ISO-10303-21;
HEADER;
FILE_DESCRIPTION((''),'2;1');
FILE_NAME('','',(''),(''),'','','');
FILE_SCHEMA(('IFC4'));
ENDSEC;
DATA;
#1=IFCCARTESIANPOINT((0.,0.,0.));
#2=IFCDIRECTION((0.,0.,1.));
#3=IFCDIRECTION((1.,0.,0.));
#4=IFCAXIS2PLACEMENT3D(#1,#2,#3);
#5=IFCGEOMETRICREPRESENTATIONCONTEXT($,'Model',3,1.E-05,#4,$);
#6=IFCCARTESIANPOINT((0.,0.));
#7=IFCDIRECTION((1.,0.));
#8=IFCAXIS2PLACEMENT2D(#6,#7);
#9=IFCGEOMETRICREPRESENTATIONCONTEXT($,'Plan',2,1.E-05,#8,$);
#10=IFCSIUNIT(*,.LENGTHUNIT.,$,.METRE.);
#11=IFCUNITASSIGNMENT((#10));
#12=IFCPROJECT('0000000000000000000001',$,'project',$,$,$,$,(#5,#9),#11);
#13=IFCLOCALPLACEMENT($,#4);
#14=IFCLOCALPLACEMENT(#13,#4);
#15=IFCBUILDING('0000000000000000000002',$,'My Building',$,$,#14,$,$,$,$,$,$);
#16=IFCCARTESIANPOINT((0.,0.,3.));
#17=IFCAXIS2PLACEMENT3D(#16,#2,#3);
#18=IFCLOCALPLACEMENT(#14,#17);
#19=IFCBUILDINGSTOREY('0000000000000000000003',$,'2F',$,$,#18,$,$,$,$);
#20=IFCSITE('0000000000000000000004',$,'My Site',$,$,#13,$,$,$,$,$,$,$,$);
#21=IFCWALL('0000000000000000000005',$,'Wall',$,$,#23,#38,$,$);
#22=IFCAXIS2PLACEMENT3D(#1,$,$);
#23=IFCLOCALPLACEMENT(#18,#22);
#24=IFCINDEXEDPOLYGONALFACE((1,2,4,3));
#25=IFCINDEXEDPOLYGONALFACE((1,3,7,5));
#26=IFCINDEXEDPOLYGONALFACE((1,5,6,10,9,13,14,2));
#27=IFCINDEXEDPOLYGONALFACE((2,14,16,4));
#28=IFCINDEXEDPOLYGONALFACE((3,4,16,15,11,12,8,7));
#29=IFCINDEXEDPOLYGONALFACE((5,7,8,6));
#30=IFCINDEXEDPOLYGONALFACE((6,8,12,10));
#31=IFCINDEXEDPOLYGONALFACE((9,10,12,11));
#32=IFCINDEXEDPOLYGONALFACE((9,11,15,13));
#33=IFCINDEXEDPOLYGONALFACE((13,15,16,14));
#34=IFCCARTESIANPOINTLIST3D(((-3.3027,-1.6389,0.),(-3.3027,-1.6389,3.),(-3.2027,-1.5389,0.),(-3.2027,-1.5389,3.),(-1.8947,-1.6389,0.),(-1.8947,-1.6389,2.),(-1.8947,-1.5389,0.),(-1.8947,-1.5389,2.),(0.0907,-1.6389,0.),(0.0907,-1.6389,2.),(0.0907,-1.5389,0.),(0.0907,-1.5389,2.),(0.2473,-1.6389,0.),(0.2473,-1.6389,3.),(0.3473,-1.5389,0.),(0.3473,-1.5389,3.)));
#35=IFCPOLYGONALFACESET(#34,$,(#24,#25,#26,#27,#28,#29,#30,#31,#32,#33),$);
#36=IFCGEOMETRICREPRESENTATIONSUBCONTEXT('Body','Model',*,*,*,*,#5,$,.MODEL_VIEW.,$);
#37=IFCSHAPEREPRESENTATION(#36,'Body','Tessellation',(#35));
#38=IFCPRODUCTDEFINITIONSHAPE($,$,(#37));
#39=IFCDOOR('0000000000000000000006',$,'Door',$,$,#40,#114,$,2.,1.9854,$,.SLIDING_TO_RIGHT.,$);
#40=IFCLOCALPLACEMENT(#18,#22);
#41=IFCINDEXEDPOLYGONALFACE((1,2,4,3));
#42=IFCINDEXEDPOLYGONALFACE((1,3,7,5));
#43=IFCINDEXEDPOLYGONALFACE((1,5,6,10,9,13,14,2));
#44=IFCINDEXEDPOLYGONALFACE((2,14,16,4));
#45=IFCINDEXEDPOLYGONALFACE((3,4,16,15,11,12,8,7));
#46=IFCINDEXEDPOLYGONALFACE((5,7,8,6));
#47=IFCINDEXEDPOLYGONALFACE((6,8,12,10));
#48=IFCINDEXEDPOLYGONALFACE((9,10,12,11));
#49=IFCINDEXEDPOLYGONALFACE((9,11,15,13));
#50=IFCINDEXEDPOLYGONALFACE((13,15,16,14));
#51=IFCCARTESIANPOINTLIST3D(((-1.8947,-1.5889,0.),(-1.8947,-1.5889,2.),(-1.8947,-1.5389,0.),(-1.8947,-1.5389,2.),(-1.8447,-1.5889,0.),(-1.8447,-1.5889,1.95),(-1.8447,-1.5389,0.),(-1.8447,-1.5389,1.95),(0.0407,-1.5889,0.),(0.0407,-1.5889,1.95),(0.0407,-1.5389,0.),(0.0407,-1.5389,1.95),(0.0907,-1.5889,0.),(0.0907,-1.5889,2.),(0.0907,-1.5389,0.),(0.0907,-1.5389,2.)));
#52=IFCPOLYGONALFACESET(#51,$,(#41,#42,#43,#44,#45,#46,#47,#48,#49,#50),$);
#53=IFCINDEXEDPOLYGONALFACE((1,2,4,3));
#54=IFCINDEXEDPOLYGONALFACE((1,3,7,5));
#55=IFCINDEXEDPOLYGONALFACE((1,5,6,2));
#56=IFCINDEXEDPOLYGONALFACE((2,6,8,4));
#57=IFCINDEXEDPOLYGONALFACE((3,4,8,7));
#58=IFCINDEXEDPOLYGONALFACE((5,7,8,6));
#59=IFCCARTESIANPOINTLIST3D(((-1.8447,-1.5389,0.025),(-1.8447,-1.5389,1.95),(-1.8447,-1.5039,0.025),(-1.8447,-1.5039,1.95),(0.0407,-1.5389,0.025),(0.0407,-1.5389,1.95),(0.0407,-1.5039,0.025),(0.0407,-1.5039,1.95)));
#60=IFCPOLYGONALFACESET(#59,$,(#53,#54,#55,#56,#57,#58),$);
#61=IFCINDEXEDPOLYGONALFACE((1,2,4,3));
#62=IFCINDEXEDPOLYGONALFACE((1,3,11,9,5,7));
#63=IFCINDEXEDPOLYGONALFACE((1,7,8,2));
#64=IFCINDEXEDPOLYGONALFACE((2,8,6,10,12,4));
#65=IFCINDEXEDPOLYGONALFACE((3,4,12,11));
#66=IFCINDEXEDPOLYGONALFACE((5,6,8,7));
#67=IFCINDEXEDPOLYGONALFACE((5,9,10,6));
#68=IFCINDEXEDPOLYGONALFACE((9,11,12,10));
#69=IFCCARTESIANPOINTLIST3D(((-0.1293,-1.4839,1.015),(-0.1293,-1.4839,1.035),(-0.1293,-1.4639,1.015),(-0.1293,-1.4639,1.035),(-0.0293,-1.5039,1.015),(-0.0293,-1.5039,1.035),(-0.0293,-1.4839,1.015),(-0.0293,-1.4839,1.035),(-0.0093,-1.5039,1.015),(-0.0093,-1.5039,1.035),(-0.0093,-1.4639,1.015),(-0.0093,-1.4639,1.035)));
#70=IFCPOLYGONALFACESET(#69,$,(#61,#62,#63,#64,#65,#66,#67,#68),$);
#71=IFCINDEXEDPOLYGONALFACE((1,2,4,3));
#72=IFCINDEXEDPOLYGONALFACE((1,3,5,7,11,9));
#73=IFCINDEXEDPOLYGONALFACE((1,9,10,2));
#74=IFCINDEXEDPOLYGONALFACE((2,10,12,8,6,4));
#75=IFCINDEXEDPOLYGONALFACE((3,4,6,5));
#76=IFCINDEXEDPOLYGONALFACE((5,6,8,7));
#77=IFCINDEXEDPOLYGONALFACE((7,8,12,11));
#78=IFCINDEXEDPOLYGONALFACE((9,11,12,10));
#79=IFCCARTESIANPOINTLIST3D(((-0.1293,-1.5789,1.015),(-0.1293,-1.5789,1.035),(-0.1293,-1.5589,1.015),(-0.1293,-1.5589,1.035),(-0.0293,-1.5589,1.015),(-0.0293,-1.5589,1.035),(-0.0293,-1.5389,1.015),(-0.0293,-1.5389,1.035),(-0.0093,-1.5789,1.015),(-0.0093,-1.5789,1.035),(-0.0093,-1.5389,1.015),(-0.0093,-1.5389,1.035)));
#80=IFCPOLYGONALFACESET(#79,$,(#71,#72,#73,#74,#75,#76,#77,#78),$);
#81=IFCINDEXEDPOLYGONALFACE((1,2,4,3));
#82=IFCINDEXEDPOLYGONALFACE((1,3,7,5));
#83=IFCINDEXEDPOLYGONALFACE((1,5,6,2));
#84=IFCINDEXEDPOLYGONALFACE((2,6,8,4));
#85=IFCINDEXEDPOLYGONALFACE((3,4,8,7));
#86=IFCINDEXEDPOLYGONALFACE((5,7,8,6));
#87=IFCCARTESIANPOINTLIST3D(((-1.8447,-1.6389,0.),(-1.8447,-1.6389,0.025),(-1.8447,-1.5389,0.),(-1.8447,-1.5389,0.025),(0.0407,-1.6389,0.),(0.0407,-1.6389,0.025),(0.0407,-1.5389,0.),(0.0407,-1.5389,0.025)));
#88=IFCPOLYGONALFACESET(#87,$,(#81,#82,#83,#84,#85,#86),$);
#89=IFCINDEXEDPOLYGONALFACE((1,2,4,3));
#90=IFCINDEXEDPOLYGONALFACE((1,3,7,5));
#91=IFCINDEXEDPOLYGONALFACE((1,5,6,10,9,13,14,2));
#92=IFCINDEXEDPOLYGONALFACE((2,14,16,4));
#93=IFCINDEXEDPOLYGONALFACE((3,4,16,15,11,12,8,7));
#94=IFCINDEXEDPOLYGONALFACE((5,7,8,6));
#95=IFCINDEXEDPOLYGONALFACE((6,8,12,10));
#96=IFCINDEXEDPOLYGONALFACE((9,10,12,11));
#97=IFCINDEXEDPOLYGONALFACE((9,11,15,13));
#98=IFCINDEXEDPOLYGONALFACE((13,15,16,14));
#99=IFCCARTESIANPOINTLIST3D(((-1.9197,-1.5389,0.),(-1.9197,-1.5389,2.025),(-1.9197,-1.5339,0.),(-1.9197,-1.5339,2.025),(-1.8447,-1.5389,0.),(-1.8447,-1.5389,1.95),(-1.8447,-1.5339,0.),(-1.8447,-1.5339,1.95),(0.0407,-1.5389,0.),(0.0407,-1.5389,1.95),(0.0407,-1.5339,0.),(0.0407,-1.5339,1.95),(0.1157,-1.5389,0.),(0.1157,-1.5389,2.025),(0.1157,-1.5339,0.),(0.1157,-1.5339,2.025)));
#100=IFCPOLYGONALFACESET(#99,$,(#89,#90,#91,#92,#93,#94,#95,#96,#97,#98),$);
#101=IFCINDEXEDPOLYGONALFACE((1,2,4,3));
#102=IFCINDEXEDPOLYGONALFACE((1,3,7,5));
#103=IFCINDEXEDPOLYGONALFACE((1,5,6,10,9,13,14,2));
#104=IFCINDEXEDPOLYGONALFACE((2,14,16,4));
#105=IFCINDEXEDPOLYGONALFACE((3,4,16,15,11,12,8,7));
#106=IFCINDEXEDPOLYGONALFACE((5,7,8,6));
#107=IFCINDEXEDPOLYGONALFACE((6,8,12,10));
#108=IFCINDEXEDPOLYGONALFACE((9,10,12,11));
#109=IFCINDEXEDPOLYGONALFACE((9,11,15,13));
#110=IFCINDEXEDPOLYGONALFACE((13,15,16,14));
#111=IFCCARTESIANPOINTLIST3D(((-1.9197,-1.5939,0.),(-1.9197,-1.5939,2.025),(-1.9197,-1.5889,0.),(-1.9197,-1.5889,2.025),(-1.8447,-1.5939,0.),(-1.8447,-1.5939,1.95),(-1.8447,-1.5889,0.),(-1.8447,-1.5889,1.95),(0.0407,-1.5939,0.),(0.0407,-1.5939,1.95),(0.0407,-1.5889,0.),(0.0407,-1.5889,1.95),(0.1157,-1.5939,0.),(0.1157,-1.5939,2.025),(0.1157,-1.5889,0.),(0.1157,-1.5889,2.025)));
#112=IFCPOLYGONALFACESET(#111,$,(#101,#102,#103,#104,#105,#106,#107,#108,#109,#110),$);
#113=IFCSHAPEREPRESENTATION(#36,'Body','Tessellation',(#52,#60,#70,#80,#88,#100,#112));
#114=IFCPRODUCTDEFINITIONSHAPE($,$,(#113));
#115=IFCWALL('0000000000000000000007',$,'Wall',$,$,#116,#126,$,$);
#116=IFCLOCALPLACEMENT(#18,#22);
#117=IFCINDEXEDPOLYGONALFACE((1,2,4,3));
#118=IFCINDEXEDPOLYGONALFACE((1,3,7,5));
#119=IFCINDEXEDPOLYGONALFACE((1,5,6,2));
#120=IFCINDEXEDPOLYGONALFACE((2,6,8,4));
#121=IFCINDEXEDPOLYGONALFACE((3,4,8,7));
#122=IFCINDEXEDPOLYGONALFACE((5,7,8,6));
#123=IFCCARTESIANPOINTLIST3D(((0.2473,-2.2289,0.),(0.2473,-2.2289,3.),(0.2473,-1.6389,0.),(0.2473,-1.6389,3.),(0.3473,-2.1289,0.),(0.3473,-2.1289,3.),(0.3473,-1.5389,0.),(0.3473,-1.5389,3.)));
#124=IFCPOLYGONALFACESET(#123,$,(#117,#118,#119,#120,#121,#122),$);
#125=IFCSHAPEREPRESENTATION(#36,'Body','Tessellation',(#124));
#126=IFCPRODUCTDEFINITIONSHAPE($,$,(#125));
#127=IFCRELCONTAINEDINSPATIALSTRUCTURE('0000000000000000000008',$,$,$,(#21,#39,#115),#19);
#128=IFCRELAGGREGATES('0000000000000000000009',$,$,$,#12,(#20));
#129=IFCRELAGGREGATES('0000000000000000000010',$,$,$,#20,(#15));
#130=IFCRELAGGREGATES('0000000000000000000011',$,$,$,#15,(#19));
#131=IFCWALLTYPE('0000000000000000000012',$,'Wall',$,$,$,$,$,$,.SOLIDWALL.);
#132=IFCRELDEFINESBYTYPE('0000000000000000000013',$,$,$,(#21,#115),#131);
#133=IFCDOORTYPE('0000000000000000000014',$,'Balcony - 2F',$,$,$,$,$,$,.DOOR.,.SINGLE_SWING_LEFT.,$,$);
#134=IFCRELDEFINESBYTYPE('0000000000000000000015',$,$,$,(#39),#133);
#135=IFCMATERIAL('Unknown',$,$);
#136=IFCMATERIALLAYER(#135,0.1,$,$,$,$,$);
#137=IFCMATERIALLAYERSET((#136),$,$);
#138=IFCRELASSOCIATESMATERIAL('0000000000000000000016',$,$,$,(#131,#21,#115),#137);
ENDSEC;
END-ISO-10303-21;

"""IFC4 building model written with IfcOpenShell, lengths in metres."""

from ifc_helpers import new_model, entity, si_unit, frame, origin_with_axes, origin_2d_with_axis, place, context, subcontext, project, spatial, line, indexed_curve, outline, extrude, shape, source, transform, mapped, material, layer, layer_set, layer_usage, type_object, type_shapes, element, fill, save


model = new_model("IFC4")

# Units and contexts
model_context = context("Model", 3, precision=1e-05, world=origin_with_axes())
plan_context = context("Plan", 2, precision=1e-05, world=origin_2d_with_axis())
body_context_1 = subcontext(model_context, "Body", "Model", "MODEL_VIEW")
body_context_2 = subcontext(plan_context, "Body", "Plan", "PLAN_VIEW")
ifc_project = project(units=[si_unit("LENGTHUNIT", "METRE")], contexts=[model_context, plan_context])

# Site, building, storey
site_placement = place(None, origin_with_axes())
site = spatial("IfcSite", under=ifc_project, at=site_placement, Name="My Site")
building_placement = place(site_placement, origin_with_axes())
building = spatial("IfcBuilding", under=site, at=building_placement, Name="My Building")
storey_placement = place(building_placement, frame((0.0, 0.0, 3.0), z_axis=(0.0, 0.0, 1.0), x_axis=(1.0, 0.0, 0.0)))
storey = spatial("IfcBuildingStorey", under=building, at=storey_placement, Name="2F")

# Shared definitions
ifc_material = material(Name="Unknown")

# Shared definitions
ifc_layer_1 = layer(ifc_material, 0.1)
ifc_layer_set_1 = layer_set([ifc_layer_1])
wall_type = type_object("IfcWallType", Name="Wall", PredefinedType="SOLIDWALL", material=ifc_layer_set_1)

# Wall, opening, door
ifc_layer_usage_1 = layer_usage(ifc_layer_set_1, "AXIS2", "POSITIVE", 0.0)
wall_1_placement = place(storey_placement, frame((-3.3027, -1.6389, 0.0), z_axis=(0.0, 0.0, 1.0), x_axis=(1.0, 0.0, 0.0)))
wall_1 = element("IfcWall", 1, at=wall_1_placement, inside=storey, type_object=wall_type, material=ifc_layer_usage_1, Name="Wall", context=body_context_1, shape_type="SweptSolid", body=[
    extrude(outline(indexed_curve([(0.0, 0.0), (0.1, 0.1), (3.65, 0.1), (3.55, 0.0)], segments=[line(1, 2, 3, 4, 1)])), origin_with_axes(), (0.0, 0.0, 1.0), 3.0),
])
shared_shape_1 = source(origin_with_axes(), body_context_1, "Body", "SweptSolid", [
    extrude(outline(indexed_curve([(0.0, 0.0), (1.9854, 0.0), (1.9854, 2.0), (0.0, 2.0)], segments=[line(1, 2, 3, 4, 1)])), frame((0.0, -0.6, 0.0), z_axis=(0.0, -1.0, 0.0), x_axis=(1.0, 0.0, 0.0)), (0.0, 0.0, -1.0), 1.2),
])
opening_1_placement = place(wall_1_placement, frame((3.3934, 0.1, 0.0), z_axis=(0.0, 0.0, 1.0), x_axis=(-1.0, 0.0, 0.0)))
opening_1 = element("IfcOpeningElement", 2, at=opening_1_placement, cuts=wall_1, PredefinedType="OPENING", context=body_context_1, shape_type="MappedRepresentation", body=[
    mapped(shared_shape_1, transform((0.0, 0.0, 0.0), x_axis=(1.0, 0.0, 0.0), y_axis=(0.0, 1.0, 0.0), z_axis=(0.0, 0.0, 1.0), scale=1.0)),
])
door_type_1 = type_object("IfcDoorType", Name="Balcony - 2F", OperationType="SINGLE_SWING_LEFT", PredefinedType="DOOR")
shared_shape_2 = source(origin_with_axes(), body_context_1, "Body", "SweptSolid", [
    extrude(outline(indexed_curve([(0.0, 0.0), (0.0, 2.0), (1.9854, 2.0), (1.9854, 0.0), (1.9354, 0.0), (1.9354, 1.95), (0.05, 1.95), (0.05, 0.0)], segments=[line(1, 2, 3, 4, 5, 6, 7, 8, 1)])), frame((0.0, 0.0, 0.0), z_axis=(0.0, -1.0, 0.0), x_axis=(1.0, 0.0, 0.0)), (0.0, 0.0, -1.0), 0.05),
    extrude(outline(indexed_curve([(0.0, 0.0), (1.8854, 0.0), (1.8854, 0.035), (0.0, 0.035)], segments=[line(1, 2, 3, 4, 1)])), frame((0.05, -0.035, 0.025), z_axis=(0.0, 0.0, 1.0), x_axis=(1.0, 0.0, 0.0)), (0.0, 0.0, 1.0), 1.925),
    extrude(outline(indexed_curve([(0.0, 0.0), (0.0, -0.04), (0.12, -0.04), (0.12, -0.02), (0.02, -0.02), (0.02, 0.0)], segments=[line(1, 2, 3, 4, 5, 6, 1)])), frame((0.1, -0.035, 1.015), z_axis=(0.0, 0.0, 1.0), x_axis=(1.0, 0.0, 0.0)), (0.0, 0.0, 1.0), 0.02),
    extrude(outline(indexed_curve([(0.0, 0.0), (0.0, 0.04), (0.12, 0.04), (0.12, 0.02), (0.02, 0.02), (0.02, 0.0)], segments=[line(1, 2, 3, 4, 5, 6, 1)])), frame((0.1, 0.0, 1.015), z_axis=(0.0, 0.0, 1.0), x_axis=(1.0, 0.0, 0.0)), (0.0, 0.0, 1.0), 0.02),
    extrude(outline(indexed_curve([(0.0, 0.0), (1.8854, 0.0), (1.8854, 0.1), (0.0, 0.1)], segments=[line(1, 2, 3, 4, 1)])), frame((0.05, 0.0, 0.0), z_axis=(0.0, 0.0, 1.0), x_axis=(1.0, 0.0, 0.0)), (0.0, 0.0, 1.0), 0.025),
    extrude(outline(indexed_curve([(0.0, 0.0), (0.0, 2.025), (2.0354, 2.025), (2.0354, 0.0), (1.9604, 0.0), (1.9604, 1.95), (0.075, 1.95), (0.075, 0.0)], segments=[line(1, 2, 3, 4, 5, 6, 7, 8, 1)])), frame((-0.025, -0.005, 0.0), z_axis=(0.0, -1.0, 0.0), x_axis=(1.0, 0.0, 0.0)), (0.0, 0.0, -1.0), 0.005),
    extrude(outline(indexed_curve([(0.0, 0.0), (0.0, 2.025), (2.0354, 2.025), (2.0354, 0.0), (1.9604, 0.0), (1.9604, 1.95), (0.075, 1.95), (0.075, 0.0)], segments=[line(1, 2, 3, 4, 5, 6, 7, 8, 1)])), frame((-0.025, 0.05, 0.0), z_axis=(0.0, -1.0, 0.0), x_axis=(1.0, 0.0, 0.0)), (0.0, 0.0, -1.0), 0.005),
])
shared_shape_3 = source(origin_with_axes(), body_context_2, "Body", "Curve2D", [
    entity("IfcIndexedPolyCurve", entity("IfcCartesianPointList2D", [[0.0, 0.0], [0.05, 0.0], [0.05, 0.05], [0.0, 0.05]]), [entity("IfcLineIndex", [1, 2, 3, 4, 1])]),
    entity("IfcIndexedPolyCurve", entity("IfcCartesianPointList2D", [[1.9854, 0.0], [1.9354, 0.0], [1.9354, 0.05], [1.9854, 0.05]]), [entity("IfcLineIndex", [1, 2, 3, 4, 1])]),
    entity("IfcIndexedPolyCurve", entity("IfcCartesianPointList2D", [[2.8782, -0.035], [0.9927, -0.035], [0.9927, 0.0], [2.8782, 0.0]]), [entity("IfcLineIndex", [1, 2, 3, 4, 1])]),
])
type_shapes(door_type_1, [shared_shape_2, shared_shape_3])
door_1_placement = place(opening_1_placement, frame((0.0, 0.0, 0.0), z_axis=(0.0, 0.0, 1.0), x_axis=(1.0, 0.0, 0.0)))
door_1 = element("IfcDoor", 3, at=door_1_placement, inside=storey, type_object=door_type_1, Name="Door", OperationType="SLIDING_TO_RIGHT", OverallHeight=2.0, OverallWidth=1.9854, shapes=[
    shape(body_context_1, "Body", "MappedRepresentation", [mapped(shared_shape_2, transform((0.0, 0.0, 0.0), x_axis=(1.0, 0.0, 0.0), y_axis=(0.0, 1.0, 0.0), z_axis=(0.0, 0.0, 1.0), scale=1.0))]),
    shape(body_context_2, "Body", "MappedRepresentation", [mapped(shared_shape_3, transform((0.0, 0.0, 0.0), x_axis=(1.0, 0.0, 0.0), y_axis=(0.0, 1.0, 0.0), z_axis=(0.0, 0.0, 1.0), scale=1.0))]),
])
fill(opening_1, door_1)

# Wall
ifc_layer_usage_2 = layer_usage(ifc_layer_set_1, "AXIS2", "POSITIVE", 0.0)
wall_2_placement = place(storey_placement, frame((0.2473, -1.6389, 0.0), z_axis=(0.0, 0.0, 1.0), x_axis=(0.0, -1.0, 0.0)))
element("IfcWall", 4, at=wall_2_placement, inside=storey, type_object=wall_type, material=ifc_layer_usage_2, Name="Wall", context=body_context_1, shape_type="SweptSolid", body=[
    extrude(outline(indexed_curve([(0.0, 0.0), (-0.1, 0.1), (0.49, 0.1), (0.59, 0.0)], segments=[line(1, 2, 3, 4, 1)])), origin_with_axes(), (0.0, 0.0, 1.0), 3.0),
])

save(model, "model.ifc")
